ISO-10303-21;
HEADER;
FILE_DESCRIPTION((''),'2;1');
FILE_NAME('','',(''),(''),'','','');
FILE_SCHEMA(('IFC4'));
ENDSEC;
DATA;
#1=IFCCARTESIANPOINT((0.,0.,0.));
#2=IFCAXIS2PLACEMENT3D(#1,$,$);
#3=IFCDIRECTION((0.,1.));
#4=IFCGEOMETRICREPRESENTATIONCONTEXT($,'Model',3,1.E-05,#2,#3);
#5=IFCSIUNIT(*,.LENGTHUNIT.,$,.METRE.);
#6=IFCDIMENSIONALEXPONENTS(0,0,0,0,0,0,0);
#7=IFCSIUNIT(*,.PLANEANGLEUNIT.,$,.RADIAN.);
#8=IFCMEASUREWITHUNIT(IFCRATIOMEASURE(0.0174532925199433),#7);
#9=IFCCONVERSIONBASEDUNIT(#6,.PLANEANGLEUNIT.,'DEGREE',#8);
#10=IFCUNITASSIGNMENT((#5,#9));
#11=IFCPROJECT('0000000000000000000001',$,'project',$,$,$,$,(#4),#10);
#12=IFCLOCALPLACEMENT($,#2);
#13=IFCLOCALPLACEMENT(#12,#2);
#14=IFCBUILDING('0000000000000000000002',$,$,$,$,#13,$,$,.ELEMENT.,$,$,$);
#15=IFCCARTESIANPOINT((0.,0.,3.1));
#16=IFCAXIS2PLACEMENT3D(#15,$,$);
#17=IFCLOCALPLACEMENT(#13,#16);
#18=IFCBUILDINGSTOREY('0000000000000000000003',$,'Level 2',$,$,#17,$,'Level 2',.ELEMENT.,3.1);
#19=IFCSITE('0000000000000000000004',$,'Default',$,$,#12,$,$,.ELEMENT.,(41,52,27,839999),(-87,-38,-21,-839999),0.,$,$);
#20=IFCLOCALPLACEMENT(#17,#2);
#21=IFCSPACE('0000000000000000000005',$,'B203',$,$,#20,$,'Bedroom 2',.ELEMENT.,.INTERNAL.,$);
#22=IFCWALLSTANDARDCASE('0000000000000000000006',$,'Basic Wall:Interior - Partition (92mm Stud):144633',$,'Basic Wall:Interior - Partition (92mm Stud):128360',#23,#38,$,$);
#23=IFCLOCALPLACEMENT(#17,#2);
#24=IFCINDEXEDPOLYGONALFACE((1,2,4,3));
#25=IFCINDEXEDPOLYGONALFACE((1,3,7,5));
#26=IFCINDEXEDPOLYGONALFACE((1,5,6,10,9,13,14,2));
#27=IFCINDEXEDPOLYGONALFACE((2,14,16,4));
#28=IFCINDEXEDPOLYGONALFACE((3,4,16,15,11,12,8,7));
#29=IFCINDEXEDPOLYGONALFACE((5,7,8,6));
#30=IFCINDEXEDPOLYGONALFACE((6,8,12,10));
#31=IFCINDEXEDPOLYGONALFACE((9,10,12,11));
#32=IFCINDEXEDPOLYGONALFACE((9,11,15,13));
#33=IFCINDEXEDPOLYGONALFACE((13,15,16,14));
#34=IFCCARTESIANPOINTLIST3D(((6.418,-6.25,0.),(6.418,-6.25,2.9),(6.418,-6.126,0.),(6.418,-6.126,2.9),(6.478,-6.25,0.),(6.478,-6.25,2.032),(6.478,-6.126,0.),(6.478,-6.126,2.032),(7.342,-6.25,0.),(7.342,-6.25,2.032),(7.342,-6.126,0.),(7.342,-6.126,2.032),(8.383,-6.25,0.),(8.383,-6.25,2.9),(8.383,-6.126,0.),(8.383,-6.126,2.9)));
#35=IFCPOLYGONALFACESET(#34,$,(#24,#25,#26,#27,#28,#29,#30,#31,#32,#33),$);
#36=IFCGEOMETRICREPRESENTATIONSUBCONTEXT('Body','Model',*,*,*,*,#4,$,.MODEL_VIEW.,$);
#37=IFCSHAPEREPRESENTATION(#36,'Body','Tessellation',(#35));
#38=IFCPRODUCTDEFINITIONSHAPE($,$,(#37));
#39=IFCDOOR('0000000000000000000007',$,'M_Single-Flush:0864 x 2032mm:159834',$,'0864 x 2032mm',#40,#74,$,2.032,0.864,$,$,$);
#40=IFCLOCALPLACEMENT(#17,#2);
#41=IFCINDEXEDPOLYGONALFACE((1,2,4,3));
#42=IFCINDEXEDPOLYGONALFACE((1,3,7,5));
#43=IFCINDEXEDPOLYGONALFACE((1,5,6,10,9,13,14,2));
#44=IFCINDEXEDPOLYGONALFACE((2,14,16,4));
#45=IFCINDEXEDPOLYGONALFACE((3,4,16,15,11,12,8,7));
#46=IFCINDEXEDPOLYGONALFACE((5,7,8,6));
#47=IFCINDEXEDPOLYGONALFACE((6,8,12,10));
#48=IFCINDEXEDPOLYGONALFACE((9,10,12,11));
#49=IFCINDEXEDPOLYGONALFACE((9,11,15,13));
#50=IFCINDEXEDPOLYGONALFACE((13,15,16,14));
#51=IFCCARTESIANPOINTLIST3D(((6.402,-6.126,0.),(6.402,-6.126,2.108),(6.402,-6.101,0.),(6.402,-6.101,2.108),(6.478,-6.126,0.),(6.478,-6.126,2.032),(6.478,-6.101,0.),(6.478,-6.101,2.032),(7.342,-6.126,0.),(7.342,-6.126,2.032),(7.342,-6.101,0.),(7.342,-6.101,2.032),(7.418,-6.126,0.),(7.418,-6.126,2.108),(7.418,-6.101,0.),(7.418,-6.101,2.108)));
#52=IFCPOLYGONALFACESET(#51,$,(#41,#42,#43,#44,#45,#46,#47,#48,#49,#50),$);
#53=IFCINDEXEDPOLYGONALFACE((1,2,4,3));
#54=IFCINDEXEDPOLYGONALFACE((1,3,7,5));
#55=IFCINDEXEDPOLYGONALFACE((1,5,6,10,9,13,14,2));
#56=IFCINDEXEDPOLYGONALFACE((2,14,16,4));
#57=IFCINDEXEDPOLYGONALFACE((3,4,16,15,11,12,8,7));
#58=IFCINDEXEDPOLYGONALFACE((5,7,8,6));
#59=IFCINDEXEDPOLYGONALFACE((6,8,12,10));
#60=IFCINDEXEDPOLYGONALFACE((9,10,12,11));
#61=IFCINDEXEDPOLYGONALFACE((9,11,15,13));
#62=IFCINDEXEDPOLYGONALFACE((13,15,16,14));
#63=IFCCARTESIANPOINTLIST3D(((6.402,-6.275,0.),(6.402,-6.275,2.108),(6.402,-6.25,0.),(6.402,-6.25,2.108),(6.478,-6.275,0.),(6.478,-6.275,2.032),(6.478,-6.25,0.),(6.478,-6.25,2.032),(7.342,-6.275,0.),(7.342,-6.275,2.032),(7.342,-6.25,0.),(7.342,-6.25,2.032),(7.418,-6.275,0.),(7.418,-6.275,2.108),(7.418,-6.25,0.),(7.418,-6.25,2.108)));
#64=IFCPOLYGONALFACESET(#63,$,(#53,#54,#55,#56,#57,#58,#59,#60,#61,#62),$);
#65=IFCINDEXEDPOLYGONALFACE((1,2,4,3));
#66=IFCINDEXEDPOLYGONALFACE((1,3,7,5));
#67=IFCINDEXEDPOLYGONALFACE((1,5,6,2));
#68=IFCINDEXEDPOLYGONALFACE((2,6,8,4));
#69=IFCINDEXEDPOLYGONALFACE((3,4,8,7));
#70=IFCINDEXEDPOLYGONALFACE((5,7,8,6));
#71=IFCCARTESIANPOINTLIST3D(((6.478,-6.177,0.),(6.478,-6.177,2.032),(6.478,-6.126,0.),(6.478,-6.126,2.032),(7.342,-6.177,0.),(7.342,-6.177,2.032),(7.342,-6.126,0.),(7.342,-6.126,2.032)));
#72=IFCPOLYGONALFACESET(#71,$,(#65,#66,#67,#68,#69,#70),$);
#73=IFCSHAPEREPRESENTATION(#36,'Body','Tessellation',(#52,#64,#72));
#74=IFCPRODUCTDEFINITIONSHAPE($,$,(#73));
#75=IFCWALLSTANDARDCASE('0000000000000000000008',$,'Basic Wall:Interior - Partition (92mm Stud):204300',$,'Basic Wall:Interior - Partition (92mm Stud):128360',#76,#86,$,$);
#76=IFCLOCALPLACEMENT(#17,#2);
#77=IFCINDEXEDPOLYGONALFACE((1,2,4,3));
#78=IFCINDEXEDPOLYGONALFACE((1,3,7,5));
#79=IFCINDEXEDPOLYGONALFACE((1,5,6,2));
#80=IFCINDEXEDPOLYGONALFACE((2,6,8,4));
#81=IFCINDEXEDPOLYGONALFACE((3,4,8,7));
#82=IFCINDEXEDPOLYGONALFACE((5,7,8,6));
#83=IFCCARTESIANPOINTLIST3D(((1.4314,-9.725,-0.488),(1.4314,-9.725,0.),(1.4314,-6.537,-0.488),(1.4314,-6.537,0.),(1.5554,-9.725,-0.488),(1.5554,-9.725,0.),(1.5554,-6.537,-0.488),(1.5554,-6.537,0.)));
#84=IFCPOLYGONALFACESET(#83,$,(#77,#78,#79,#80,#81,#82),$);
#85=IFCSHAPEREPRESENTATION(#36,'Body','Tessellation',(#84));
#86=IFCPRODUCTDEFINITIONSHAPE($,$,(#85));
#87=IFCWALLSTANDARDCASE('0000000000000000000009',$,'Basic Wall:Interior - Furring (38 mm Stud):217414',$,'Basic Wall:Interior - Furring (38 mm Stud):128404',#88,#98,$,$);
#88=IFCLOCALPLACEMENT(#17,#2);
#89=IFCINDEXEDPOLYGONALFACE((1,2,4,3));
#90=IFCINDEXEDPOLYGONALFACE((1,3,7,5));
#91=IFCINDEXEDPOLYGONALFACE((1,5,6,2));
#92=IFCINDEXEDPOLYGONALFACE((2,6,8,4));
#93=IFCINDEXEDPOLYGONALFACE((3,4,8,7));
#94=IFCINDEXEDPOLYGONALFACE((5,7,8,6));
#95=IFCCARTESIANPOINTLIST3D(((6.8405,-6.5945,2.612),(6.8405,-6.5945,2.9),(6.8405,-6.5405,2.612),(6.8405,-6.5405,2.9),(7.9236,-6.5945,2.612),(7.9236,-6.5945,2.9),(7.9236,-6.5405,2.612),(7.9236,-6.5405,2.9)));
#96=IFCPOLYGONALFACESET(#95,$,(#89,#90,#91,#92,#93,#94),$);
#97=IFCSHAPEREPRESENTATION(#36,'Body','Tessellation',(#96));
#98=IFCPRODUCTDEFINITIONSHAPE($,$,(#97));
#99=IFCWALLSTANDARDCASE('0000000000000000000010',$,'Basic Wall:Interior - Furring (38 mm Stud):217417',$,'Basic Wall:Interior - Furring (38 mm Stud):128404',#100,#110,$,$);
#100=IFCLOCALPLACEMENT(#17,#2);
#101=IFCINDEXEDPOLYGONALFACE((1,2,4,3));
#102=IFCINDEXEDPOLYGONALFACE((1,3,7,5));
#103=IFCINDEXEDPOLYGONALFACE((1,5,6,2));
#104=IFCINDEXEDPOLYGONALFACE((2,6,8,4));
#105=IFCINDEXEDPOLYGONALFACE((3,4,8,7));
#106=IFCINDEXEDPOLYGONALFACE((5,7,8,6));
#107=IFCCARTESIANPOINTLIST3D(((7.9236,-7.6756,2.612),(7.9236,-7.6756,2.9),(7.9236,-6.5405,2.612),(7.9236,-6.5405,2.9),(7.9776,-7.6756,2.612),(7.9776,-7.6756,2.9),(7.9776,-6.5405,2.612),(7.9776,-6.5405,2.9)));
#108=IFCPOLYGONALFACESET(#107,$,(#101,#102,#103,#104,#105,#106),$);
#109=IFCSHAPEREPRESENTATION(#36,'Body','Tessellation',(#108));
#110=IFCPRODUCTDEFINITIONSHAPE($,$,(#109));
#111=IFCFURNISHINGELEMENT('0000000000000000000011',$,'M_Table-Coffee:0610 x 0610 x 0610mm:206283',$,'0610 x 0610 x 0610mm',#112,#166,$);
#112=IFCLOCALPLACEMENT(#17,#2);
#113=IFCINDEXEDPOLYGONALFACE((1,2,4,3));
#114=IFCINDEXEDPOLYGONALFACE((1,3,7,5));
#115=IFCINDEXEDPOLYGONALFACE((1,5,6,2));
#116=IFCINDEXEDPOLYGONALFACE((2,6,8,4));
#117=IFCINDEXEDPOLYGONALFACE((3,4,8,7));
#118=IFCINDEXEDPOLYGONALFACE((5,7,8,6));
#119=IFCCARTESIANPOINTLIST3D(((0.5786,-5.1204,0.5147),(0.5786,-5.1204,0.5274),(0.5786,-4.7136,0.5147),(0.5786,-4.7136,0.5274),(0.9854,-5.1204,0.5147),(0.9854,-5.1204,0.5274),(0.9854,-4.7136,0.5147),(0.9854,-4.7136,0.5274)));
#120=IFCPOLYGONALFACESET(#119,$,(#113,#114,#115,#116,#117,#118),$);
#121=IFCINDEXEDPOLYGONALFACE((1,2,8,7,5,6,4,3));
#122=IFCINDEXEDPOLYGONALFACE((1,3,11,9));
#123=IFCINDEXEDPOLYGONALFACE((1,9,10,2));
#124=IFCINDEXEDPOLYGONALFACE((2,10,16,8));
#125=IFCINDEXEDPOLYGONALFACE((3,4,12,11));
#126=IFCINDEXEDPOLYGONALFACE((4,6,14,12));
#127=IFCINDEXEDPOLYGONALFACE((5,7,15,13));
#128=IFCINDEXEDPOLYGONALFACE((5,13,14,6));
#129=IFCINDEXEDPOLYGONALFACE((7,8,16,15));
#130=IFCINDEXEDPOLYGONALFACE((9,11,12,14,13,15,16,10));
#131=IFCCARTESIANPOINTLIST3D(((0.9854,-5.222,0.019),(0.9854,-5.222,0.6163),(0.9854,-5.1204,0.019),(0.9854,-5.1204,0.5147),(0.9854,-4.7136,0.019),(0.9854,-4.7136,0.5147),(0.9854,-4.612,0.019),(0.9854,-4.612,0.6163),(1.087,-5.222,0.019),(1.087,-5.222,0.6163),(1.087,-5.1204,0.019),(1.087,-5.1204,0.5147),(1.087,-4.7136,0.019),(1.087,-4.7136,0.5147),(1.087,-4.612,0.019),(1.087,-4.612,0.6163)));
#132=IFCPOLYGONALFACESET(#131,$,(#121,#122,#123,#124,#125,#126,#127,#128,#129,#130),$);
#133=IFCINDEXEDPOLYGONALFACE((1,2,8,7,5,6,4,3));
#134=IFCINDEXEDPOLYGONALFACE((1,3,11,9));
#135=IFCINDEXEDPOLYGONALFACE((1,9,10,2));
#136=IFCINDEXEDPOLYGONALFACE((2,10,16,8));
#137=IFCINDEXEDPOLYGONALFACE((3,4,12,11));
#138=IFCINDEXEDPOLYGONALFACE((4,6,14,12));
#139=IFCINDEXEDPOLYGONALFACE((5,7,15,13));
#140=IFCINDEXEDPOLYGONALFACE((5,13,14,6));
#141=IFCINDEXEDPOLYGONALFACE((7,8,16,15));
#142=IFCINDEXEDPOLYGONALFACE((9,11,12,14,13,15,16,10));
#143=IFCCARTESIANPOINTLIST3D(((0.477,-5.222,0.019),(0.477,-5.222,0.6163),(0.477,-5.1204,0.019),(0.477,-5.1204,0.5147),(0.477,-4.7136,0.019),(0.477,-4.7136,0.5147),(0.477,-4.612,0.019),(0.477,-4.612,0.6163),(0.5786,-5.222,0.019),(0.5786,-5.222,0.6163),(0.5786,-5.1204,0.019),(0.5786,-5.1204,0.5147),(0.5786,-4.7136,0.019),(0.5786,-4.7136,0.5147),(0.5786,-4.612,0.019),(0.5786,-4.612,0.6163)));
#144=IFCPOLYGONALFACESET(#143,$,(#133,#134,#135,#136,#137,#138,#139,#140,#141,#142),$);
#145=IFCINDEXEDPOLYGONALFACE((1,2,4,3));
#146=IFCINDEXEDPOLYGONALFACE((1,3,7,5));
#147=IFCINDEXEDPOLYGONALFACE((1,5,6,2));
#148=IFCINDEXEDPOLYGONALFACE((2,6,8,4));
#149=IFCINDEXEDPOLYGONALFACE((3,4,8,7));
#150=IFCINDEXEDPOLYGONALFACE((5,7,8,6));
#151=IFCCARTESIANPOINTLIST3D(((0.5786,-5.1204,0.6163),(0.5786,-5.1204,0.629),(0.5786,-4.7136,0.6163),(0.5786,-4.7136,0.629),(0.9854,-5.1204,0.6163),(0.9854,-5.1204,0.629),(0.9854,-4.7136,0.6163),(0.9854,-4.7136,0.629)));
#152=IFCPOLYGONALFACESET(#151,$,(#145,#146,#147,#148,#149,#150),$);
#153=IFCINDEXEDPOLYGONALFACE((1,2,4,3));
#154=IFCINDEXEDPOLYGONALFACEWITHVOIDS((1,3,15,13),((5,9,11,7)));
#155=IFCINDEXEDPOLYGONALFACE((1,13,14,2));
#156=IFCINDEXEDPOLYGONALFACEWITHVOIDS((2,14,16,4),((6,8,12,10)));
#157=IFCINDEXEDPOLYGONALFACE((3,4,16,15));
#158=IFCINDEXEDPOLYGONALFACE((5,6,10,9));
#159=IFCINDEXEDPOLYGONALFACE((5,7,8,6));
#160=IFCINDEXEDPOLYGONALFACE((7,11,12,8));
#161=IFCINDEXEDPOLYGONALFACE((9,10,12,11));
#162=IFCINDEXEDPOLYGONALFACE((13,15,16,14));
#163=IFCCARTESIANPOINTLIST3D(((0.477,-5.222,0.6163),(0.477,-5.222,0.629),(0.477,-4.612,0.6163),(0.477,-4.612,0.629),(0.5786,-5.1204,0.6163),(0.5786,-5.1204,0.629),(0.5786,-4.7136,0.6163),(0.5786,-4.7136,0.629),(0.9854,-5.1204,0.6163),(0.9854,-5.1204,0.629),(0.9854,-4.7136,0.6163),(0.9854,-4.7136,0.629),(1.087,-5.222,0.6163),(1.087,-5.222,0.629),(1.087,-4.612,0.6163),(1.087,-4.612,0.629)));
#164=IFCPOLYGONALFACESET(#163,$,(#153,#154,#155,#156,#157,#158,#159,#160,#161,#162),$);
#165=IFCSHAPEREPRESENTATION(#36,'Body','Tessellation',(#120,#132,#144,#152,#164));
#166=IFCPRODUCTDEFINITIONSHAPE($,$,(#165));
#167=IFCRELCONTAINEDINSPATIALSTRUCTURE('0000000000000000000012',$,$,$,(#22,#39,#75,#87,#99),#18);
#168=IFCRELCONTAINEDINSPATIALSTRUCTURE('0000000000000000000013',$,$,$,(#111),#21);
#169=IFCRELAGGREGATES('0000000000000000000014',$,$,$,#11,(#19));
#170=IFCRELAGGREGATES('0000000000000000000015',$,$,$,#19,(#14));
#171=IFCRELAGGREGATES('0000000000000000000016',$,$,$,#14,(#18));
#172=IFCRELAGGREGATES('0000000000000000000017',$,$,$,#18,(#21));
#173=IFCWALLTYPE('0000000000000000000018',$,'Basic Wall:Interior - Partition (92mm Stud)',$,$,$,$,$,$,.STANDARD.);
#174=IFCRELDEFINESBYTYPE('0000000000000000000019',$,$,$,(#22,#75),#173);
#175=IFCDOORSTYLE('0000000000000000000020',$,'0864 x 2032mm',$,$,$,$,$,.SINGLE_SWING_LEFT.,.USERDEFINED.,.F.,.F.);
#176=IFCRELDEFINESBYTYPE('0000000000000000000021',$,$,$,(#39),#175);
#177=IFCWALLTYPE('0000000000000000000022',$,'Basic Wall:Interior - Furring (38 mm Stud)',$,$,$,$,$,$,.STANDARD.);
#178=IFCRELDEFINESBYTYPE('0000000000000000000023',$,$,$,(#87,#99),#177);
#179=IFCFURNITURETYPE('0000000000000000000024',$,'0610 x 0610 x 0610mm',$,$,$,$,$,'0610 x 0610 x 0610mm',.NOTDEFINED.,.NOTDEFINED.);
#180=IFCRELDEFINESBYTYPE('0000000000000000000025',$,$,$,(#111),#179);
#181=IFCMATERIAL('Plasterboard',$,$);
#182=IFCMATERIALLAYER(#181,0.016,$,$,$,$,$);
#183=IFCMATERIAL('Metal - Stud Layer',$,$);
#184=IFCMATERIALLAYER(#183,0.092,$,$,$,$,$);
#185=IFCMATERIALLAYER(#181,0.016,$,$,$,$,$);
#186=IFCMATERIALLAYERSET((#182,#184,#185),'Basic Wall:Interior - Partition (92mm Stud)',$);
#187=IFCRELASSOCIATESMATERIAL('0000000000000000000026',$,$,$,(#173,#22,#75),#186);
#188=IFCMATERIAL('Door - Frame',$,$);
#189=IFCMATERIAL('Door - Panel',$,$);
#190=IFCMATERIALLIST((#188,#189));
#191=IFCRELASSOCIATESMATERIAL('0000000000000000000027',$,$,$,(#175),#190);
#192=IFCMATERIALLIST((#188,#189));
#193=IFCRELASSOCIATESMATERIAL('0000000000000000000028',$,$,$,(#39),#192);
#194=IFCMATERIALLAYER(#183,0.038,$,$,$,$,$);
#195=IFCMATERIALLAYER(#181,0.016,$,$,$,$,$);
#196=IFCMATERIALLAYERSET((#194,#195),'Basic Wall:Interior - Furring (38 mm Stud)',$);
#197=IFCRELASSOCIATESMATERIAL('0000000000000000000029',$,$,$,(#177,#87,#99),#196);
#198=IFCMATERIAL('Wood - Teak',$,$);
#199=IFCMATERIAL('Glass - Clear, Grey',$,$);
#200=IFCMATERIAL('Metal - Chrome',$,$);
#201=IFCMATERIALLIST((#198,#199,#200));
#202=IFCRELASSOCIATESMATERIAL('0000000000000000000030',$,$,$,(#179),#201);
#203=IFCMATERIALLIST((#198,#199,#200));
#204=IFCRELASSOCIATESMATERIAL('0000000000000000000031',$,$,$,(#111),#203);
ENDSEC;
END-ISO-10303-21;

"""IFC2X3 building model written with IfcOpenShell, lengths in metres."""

from ifc_helpers import new_model, entity, si_unit, converted_unit, direction, frame, frame_2d, origin, origin_2d_with_axis, place, context, subcontext, project, spatial, polyline, rectangle, outline, extrude, source, transform, mapped, material, material_list, layer, layer_set, layer_usage, type_object, type_shapes, element, fill, save


model = new_model("IFC2X3")

# Units and contexts
model_context = context("Model", 3, precision=1e-05, world=origin(), true_north=direction((0.0, 1.0)))
body_context = subcontext(model_context, "Body", "Model", "MODEL_VIEW")
ifc_project = project(units=[si_unit("LENGTHUNIT", "METRE"), converted_unit("PLANEANGLEUNIT", "DEGREE", entity("IfcRatioMeasure", 0.0174532925199433), si_unit("PLANEANGLEUNIT", "RADIAN"), dimensions=[0, 0, 0, 0, 0, 0, 0])], contexts=[model_context])

# Site, building, storey
site_placement = place(None, origin())
site = spatial("IfcSite", under=ifc_project, at=site_placement, Name="Default", CompositionType="ELEMENT", RefLatitude=(41, 52, 27, 839999), RefLongitude=(-87, -38, -21, -839999), RefElevation=0.0)
building_placement = place(site_placement, origin())
building = spatial("IfcBuilding", under=site, at=building_placement, CompositionType="ELEMENT")
storey_placement = place(building_placement, frame((0.0, 0.0, 3.1)))
storey = spatial("IfcBuildingStorey", under=building, at=storey_placement, Name="Level 2", LongName="Level 2", CompositionType="ELEMENT", Elevation=3.1)

# Shared definitions
ifc_material_1 = material(Name="Metal - Stud Layer")
ifc_material_2 = material(Name="Plasterboard")

# Wall, opening, door
ifc_layer_1 = layer(ifc_material_2, 0.016)
ifc_layer_2 = layer(ifc_material_1, 0.092)
ifc_layer_3 = layer(ifc_material_2, 0.016)
ifc_layer_set_1 = layer_set([ifc_layer_1, ifc_layer_2, ifc_layer_3], Name="Basic Wall:Interior - Partition (92mm Stud)")
wall_type_1 = type_object("IfcWallType", Name="Basic Wall:Interior - Partition (92mm Stud)", PredefinedType="STANDARD", material=ifc_layer_set_1)
ifc_material_3 = material(Name="Door - Frame")
ifc_material_4 = material(Name="Door - Panel")
ifc_layer_usage_1 = layer_usage(ifc_layer_set_1, "AXIS2", "NEGATIVE", 0.062)
wall_1_placement = place(storey_placement, frame((6.418, -6.188, 0.0)))
wall_1 = element("IfcWallStandardCase", 1, at=wall_1_placement, inside=storey, type_object=wall_type_1, material=ifc_layer_usage_1, Name="Basic Wall:Interior - Partition (92mm Stud):144633", ObjectType="Basic Wall:Interior - Partition (92mm Stud):128360", context=body_context, shape_type="SweptSolid", body=[
    extrude(rectangle(XDim=1.965, YDim=0.124, at=frame_2d((0.9825, 0.0), x_axis=(-1.0, 0.0))), origin(), (0.0, 0.0, 1.0), 2.9),
])
opening_1_placement = place(wall_1_placement, frame((0.06, -0.062, 0.0)))
opening_1 = element("IfcOpeningElement", 2, at=opening_1_placement, cuts=wall_1, ObjectType="Opening", context=body_context, shape_type="SweptSolid", body=[
    extrude(rectangle(XDim=0.864, YDim=2.032, at=frame_2d((1.016, 0.432), x_axis=(0.0, -1.0))), frame((0.0, 0.0, 0.0), z_axis=(0.0, 1.0, 0.0), x_axis=(0.0, 0.0, 1.0)), (0.0, 0.0, 1.0), 0.124),
])
ifc_material_list_1 = material_list([ifc_material_3, ifc_material_4])
ifc_material_list_2 = material_list([ifc_material_3, ifc_material_4])
door_style_1 = type_object("IfcDoorStyle", Name="0864 x 2032mm", ConstructionType="USERDEFINED", OperationType="SINGLE_SWING_LEFT", ParameterTakesPrecedence=False, Sizeable=False, material=ifc_material_list_2)
shared_shape_1 = source(origin(), body_context, "Body", "SweptSolid", [
    extrude(outline(polyline([(-0.508, -1.073), (0.508, -1.073), (0.508, 1.035), (0.432, 1.035), (0.432, -0.997), (-0.432, -0.997), (-0.432, 1.035), (-0.508, 1.035), (-0.508, -1.073)])), frame((0.432, 0.149, 1.035), z_axis=(0.0, -1.0, 0.0), x_axis=(-1.0, 0.0, 0.0)), (0.0, 0.0, 1.0), 0.025),
    extrude(outline(polyline([(-1.073, -0.508), (1.035, -0.508), (1.035, -0.432), (-0.997, -0.432), (-0.997, 0.432), (1.035, 0.432), (1.035, 0.508), (-1.073, 0.508), (-1.073, -0.508)])), frame((0.432, 0.0, 1.035), z_axis=(0.0, -1.0, 0.0), x_axis=(0.0, 0.0, -1.0)), (0.0, 0.0, 1.0), 0.025),
    extrude(rectangle(XDim=0.864, YDim=0.051, at=frame_2d((0.0, 0.0), x_axis=(1.0, 0.0))), frame((0.432, 0.0985, 0.0)), (0.0, 0.0, 1.0), 2.032),
])
type_shapes(door_style_1, [shared_shape_1])
door_1_placement = place(opening_1_placement, origin())
door_1 = element("IfcDoor", 3, at=door_1_placement, inside=storey, type_object=door_style_1, material=ifc_material_list_1, Name="M_Single-Flush:0864 x 2032mm:159834", ObjectType="0864 x 2032mm", OverallHeight=2.032, OverallWidth=0.864, context=body_context, shape_type="MappedRepresentation", body=[
    mapped(shared_shape_1, transform((0.0, 0.0, 0.0), scale=1.0)),
])
fill(opening_1, door_1)

# Walls
ifc_layer_usage_2 = layer_usage(ifc_layer_set_1, "AXIS2", "NEGATIVE", 0.062)
wall_2_placement = place(storey_placement, frame((1.4934, -6.537, -0.488), z_axis=(0.0, 0.0, 1.0), x_axis=(0.0, -1.0, 0.0)))
element("IfcWallStandardCase", 4, at=wall_2_placement, inside=storey, type_object=wall_type_1, material=ifc_layer_usage_2, Name="Basic Wall:Interior - Partition (92mm Stud):204300", ObjectType="Basic Wall:Interior - Partition (92mm Stud):128360", context=body_context, shape_type="SweptSolid", body=[
    extrude(rectangle(XDim=3.188, YDim=0.124, at=frame_2d((1.594, 0.0), x_axis=(-1.0, 0.0))), origin(), (0.0, 0.0, 1.0), 0.488),
])
ifc_layer_4 = layer(ifc_material_1, 0.038)
ifc_layer_5 = layer(ifc_material_2, 0.016)
ifc_layer_set_2 = layer_set([ifc_layer_4, ifc_layer_5], Name="Basic Wall:Interior - Furring (38 mm Stud)")
ifc_layer_usage_3 = layer_usage(ifc_layer_set_2, "AXIS2", "NEGATIVE", 0.027)
wall_type_2 = type_object("IfcWallType", Name="Basic Wall:Interior - Furring (38 mm Stud)", PredefinedType="STANDARD", material=ifc_layer_set_2)
wall_3_placement = place(storey_placement, frame((6.8405, -6.5675, 2.612)))
element("IfcWallStandardCase", 5, at=wall_3_placement, inside=storey, type_object=wall_type_2, material=ifc_layer_usage_3, Name="Basic Wall:Interior - Furring (38 mm Stud):217414", ObjectType="Basic Wall:Interior - Furring (38 mm Stud):128404", context=body_context, shape_type="SweptSolid", body=[
    extrude(rectangle(XDim=1.0831, YDim=0.054, at=frame_2d((0.5415, 0.0), x_axis=(-1.0, 0.0))), origin(), (0.0, 0.0, 1.0), 0.288),
])
ifc_layer_usage_4 = layer_usage(ifc_layer_set_2, "AXIS2", "NEGATIVE", 0.027)
wall_4_placement = place(storey_placement, frame((7.9506, -6.5405, 2.612), z_axis=(0.0, 0.0, 1.0), x_axis=(0.0, -1.0, 0.0)))
element("IfcWallStandardCase", 6, at=wall_4_placement, inside=storey, type_object=wall_type_2, material=ifc_layer_usage_4, Name="Basic Wall:Interior - Furring (38 mm Stud):217417", ObjectType="Basic Wall:Interior - Furring (38 mm Stud):128404", context=body_context, shape_type="SweptSolid", body=[
    extrude(rectangle(XDim=1.1351, YDim=0.054, at=frame_2d((0.5675, 0.0), x_axis=(-1.0, 0.0))), origin(), (0.0, 0.0, 1.0), 0.288),
])

# Shared definitions
space_1_placement = place(storey_placement, origin())
space_1 = spatial("IfcSpace", under=storey, at=space_1_placement, Name="B203", LongName="Bedroom 2", CompositionType="ELEMENT", InteriorOrExteriorSpace="INTERNAL")

# Furnishing element
ifc_material_5 = material(Name="Wood - Teak")
ifc_material_6 = material(Name="Glass - Clear, Grey")
ifc_material_7 = material(Name="Metal - Chrome")
ifc_material_list_3 = material_list([ifc_material_5, ifc_material_6, ifc_material_7])
ifc_material_list_4 = material_list([ifc_material_5, ifc_material_6, ifc_material_7])
furniture_type_1 = type_object("IfcFurnitureType", Name="0610 x 0610 x 0610mm", ElementType="0610 x 0610 x 0610mm", material=ifc_material_list_4)
shared_shape_2 = source(origin(), body_context, "Body", "SweptSolid", [
    extrude(rectangle(XDim=0.4068, YDim=0.4068, at=origin_2d_with_axis()), frame((0.0183, 0.0952, 0.4957), z_axis=(0.0, 0.0, 1.0), x_axis=(-1.0, 0.0, 0.0)), (0.0, 0.0, 1.0), 0.0127),
    extrude(outline(polyline([(-0.2732, -0.305), (0.324, -0.305), (0.324, 0.305), (-0.2732, 0.305), (-0.2732, 0.2034), (0.2225, 0.2034), (0.2225, -0.2034), (-0.2732, -0.2034), (-0.2732, -0.305)])), frame((0.2217, 0.0952, 0.2732), z_axis=(1.0, 0.0, 0.0), x_axis=(0.0, 0.0, 1.0)), (0.0, 0.0, 1.0), 0.1016),
    extrude(outline(polyline([(-0.305, -0.3241), (0.305, -0.3241), (0.305, 0.2733), (0.2034, 0.2733), (0.2034, -0.2224), (-0.2034, -0.2224), (-0.2034, 0.2733), (-0.305, 0.2733), (-0.305, -0.3241)])), frame((-0.2867, 0.0952, 0.2733), z_axis=(1.0, 0.0, 0.0), x_axis=(0.0, -1.0, 0.0)), (0.0, 0.0, 1.0), 0.1016),
    extrude(rectangle(XDim=0.4068, YDim=0.4068, at=origin_2d_with_axis()), frame((0.0183, 0.0952, 0.5973), z_axis=(0.0, 0.0, 1.0), x_axis=(-1.0, 0.0, 0.0)), (0.0, 0.0, 1.0), 0.0127),
    extrude(outline(polyline([(-0.305, -0.305), (0.305, -0.305), (0.305, 0.305), (-0.305, 0.305), (-0.305, -0.305)]), holes=[polyline([(-0.2034, -0.2034), (-0.2034, 0.2034), (0.2034, 0.2034), (0.2034, -0.2034), (-0.2034, -0.2034)])]), frame((0.0183, 0.0952, 0.5973), z_axis=(0.0, 0.0, 1.0), x_axis=(-1.0, 0.0, 0.0)), (0.0, 0.0, 1.0), 0.0127),
])
type_shapes(furniture_type_1, [shared_shape_2])
furnishing_1_placement = place(space_1_placement, frame((0.7637, -5.0122, 0.019)))
element("IfcFurnishingElement", 7, at=furnishing_1_placement, inside=space_1, type_object=furniture_type_1, material=ifc_material_list_3, Name="M_Table-Coffee:0610 x 0610 x 0610mm:206283", ObjectType="0610 x 0610 x 0610mm", context=body_context, shape_type="MappedRepresentation", body=[
    mapped(shared_shape_2, transform((0.0, 0.0, 0.0), scale=1.0)),
])

save(model, "model.ifc")
